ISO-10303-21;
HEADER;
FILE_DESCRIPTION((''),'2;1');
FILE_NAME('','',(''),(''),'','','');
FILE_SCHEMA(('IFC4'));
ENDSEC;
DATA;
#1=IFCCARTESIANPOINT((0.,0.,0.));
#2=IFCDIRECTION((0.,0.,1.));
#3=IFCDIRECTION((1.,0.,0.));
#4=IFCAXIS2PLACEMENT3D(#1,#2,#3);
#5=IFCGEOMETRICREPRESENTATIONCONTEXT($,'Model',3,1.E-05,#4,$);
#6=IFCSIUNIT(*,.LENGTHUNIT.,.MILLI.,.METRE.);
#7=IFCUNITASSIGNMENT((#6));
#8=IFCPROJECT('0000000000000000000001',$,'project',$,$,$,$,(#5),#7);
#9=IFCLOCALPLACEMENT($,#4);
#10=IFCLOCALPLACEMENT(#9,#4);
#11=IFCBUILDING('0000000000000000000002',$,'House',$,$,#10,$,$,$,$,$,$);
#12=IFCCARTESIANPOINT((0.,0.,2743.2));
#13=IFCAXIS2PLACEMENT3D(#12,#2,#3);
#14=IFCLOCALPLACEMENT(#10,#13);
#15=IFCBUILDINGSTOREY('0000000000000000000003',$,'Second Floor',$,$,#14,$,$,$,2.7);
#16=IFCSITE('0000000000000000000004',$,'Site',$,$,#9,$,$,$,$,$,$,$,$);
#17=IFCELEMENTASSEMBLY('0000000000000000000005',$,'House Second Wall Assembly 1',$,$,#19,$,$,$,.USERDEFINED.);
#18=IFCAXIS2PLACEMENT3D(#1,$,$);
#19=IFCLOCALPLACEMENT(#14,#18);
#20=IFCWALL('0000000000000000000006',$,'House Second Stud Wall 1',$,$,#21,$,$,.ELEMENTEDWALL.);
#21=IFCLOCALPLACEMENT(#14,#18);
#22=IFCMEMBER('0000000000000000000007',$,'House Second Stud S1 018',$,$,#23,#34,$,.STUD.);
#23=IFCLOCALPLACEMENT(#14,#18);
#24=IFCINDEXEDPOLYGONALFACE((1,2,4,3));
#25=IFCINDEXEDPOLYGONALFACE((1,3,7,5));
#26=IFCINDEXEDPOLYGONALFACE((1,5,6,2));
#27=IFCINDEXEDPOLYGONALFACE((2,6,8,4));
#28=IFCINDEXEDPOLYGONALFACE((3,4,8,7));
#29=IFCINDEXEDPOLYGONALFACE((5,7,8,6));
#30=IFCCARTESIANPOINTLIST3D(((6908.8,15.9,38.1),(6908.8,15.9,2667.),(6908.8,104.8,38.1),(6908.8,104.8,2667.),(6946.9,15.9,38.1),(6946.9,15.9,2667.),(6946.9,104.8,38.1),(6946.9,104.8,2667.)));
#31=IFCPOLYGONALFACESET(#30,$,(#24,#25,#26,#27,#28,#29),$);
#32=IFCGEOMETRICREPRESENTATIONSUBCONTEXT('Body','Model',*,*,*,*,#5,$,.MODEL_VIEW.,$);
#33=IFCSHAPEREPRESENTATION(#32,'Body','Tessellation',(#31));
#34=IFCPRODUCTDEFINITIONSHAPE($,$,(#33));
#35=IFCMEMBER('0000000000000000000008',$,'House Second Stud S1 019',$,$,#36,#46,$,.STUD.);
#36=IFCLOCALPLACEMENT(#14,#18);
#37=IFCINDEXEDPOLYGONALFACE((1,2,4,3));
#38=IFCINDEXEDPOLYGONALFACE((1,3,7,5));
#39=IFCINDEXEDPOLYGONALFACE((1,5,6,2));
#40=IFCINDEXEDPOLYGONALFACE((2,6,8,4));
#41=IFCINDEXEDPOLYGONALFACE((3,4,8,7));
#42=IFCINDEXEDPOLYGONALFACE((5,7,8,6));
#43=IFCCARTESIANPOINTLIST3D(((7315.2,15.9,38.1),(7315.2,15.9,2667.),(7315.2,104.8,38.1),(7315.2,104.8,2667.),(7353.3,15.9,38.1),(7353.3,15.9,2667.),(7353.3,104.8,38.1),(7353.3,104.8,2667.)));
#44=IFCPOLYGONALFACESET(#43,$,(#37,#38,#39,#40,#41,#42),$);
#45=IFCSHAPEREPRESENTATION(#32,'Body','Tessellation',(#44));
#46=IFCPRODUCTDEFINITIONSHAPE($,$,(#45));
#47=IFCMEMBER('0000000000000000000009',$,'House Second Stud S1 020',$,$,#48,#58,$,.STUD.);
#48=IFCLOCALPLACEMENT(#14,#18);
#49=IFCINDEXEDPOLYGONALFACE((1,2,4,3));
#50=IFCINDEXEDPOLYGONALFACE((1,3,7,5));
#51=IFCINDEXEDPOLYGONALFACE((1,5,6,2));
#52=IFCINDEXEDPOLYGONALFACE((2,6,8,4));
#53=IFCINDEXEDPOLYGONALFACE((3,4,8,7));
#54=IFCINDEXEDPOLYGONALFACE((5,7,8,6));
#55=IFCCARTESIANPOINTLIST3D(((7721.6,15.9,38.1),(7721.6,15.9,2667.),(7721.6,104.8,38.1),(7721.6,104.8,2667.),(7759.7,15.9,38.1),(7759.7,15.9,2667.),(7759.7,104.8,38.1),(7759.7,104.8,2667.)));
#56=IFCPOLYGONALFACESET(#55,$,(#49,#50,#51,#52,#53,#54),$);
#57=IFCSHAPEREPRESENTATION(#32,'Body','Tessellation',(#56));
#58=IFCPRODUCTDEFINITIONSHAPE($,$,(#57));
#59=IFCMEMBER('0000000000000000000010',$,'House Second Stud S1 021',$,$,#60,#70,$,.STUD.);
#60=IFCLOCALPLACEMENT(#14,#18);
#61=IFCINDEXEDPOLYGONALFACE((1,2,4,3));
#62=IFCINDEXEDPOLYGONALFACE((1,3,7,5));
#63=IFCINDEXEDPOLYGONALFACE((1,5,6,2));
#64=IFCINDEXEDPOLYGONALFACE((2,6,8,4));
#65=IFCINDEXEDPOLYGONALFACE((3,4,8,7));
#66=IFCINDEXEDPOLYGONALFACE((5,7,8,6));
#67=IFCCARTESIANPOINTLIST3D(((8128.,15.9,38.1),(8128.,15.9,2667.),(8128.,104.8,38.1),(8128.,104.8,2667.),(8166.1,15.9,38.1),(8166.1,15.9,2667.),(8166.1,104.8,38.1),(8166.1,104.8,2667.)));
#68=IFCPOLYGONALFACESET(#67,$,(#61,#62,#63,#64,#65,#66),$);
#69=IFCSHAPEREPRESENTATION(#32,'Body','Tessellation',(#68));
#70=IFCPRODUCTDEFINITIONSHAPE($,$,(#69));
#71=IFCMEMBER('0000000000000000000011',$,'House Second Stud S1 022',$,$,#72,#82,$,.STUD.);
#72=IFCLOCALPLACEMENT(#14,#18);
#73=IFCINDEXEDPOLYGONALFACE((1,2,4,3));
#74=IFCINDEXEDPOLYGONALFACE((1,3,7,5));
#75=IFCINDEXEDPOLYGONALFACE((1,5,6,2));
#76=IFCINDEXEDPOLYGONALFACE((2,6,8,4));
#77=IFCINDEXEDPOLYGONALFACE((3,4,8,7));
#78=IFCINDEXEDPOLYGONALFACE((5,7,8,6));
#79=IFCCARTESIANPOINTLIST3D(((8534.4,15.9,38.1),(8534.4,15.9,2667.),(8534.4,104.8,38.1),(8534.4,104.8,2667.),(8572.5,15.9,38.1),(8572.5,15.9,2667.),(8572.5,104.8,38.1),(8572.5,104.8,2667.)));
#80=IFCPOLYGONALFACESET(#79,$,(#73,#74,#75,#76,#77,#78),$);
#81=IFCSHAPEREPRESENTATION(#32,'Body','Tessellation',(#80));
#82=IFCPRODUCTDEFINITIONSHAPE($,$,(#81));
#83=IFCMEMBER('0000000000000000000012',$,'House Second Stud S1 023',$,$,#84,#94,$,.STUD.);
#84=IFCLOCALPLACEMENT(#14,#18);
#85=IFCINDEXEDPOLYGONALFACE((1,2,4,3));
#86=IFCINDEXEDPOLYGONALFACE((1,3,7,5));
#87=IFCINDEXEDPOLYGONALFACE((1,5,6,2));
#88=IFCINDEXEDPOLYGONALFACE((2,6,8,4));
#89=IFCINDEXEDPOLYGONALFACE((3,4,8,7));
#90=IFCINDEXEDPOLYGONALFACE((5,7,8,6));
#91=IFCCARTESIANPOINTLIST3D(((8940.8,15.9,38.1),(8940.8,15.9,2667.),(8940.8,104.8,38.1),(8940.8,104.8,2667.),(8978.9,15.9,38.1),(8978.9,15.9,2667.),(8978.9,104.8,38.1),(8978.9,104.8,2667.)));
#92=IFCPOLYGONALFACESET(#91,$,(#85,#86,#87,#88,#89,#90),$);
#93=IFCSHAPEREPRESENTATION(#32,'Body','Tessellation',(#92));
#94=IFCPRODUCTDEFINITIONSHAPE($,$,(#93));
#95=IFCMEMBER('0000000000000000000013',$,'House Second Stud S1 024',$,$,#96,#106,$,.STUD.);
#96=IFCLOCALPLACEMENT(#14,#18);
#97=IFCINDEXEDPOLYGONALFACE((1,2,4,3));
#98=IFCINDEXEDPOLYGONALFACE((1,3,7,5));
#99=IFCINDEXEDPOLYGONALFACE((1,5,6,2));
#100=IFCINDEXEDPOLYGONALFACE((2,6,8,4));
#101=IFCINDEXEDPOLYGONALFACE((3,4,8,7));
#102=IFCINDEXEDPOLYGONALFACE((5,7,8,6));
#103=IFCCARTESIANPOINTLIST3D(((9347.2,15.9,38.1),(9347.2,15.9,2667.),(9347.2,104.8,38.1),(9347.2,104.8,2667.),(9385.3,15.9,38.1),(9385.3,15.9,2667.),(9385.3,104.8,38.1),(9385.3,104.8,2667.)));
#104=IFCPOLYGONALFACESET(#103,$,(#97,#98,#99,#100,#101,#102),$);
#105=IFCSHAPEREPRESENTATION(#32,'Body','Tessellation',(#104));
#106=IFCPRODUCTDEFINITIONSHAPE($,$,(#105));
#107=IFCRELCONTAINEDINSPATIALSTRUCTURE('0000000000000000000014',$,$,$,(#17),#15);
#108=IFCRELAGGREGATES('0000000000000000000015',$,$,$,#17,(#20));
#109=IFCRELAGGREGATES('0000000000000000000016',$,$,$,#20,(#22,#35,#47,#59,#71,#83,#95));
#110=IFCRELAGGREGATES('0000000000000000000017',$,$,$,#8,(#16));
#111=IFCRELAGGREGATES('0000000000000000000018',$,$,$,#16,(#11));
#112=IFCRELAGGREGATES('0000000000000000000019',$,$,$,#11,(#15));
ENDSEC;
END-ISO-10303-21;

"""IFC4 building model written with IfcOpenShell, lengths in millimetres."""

from ifc_helpers import new_model, si_unit, frame, origin_with_axes, origin_2d, place, context, subcontext, project, spatial, rectangle, extrude, element, aggregate, save


model = new_model("IFC4")

# Units and contexts
model_context = context("Model", 3, precision=1e-05, world=origin_with_axes())
body_context = subcontext(model_context, "Body", "Model", "MODEL_VIEW")
ifc_project = project(units=[si_unit("LENGTHUNIT", "METRE", prefix="MILLI")], contexts=[model_context])

# Site, building, storey
site_placement = place(None, origin_with_axes())
site = spatial("IfcSite", under=ifc_project, at=site_placement, Name="Site")
building_placement = place(site_placement, origin_with_axes())
building = spatial("IfcBuilding", under=site, at=building_placement, Name="House")
storey_placement = place(building_placement, frame((0.0, 0.0, 2743.2), z_axis=(0.0, 0.0, 1.0), x_axis=(1.0, 0.0, 0.0)))
storey = spatial("IfcBuildingStorey", under=building, at=storey_placement, Name="Second Floor", Elevation=2.7)

# Element assembly, wall, members
assembly_placement = place(storey_placement, frame((0.0, 0.0, -2743.2), z_axis=(0.0, 0.0, 1.0), x_axis=(1.0, 0.0, 0.0)))
assembly = element("IfcElementAssembly", 1, at=assembly_placement, inside=storey, Name="House Second Wall Assembly 1", PredefinedType="USERDEFINED")
wall_placement = place(assembly_placement, frame((0.0, 0.0, 2743.2), z_axis=(0.0, 0.0, 1.0), x_axis=(1.0, 0.0, 0.0)))
wall = element("IfcWall", 2, at=wall_placement, Name="House Second Stud Wall 1", PredefinedType="ELEMENTEDWALL")
aggregate(assembly, [wall])
member_1_placement = place(wall_placement, frame((6927.9, 60.3, 38.1), z_axis=(0.0, 0.0, 1.0), x_axis=(1.0, 0.0, 0.0)))
member_1 = element("IfcMember", 3, at=member_1_placement, Name="House Second Stud S1 018", PredefinedType="STUD", context=body_context, shape_type="SweptSolid", body=[
    extrude(rectangle(XDim=38.1, YDim=88.9, at=origin_2d()), origin_with_axes(), (0.0, 0.0, 1.0), 2628.9),
])
member_2_placement = place(wall_placement, frame((7334.2, 60.3, 38.1), z_axis=(0.0, 0.0, 1.0), x_axis=(1.0, 0.0, 0.0)))
member_2 = element("IfcMember", 4, at=member_2_placement, Name="House Second Stud S1 019", PredefinedType="STUD", context=body_context, shape_type="SweptSolid", body=[
    extrude(rectangle(XDim=38.1, YDim=88.9, at=origin_2d()), origin_with_axes(), (0.0, 0.0, 1.0), 2628.9),
])
member_3_placement = place(wall_placement, frame((7740.6, 60.3, 38.1), z_axis=(0.0, 0.0, 1.0), x_axis=(1.0, 0.0, 0.0)))
member_3 = element("IfcMember", 5, at=member_3_placement, Name="House Second Stud S1 020", PredefinedType="STUD", context=body_context, shape_type="SweptSolid", body=[
    extrude(rectangle(XDim=38.1, YDim=88.9, at=origin_2d()), origin_with_axes(), (0.0, 0.0, 1.0), 2628.9),
])
member_4_placement = place(wall_placement, frame((8147.1, 60.3, 38.1), z_axis=(0.0, 0.0, 1.0), x_axis=(1.0, 0.0, 0.0)))
member_4 = element("IfcMember", 6, at=member_4_placement, Name="House Second Stud S1 021", PredefinedType="STUD", context=body_context, shape_type="SweptSolid", body=[
    extrude(rectangle(XDim=38.1, YDim=88.9, at=origin_2d()), origin_with_axes(), (0.0, 0.0, 1.0), 2628.9),
])
member_5_placement = place(wall_placement, frame((8553.5, 60.3, 38.1), z_axis=(0.0, 0.0, 1.0), x_axis=(1.0, 0.0, 0.0)))
member_5 = element("IfcMember", 7, at=member_5_placement, Name="House Second Stud S1 022", PredefinedType="STUD", context=body_context, shape_type="SweptSolid", body=[
    extrude(rectangle(XDim=38.1, YDim=88.9, at=origin_2d()), origin_with_axes(), (0.0, 0.0, 1.0), 2628.9),
])
member_6_placement = place(wall_placement, frame((8959.8, 60.3, 38.1), z_axis=(0.0, 0.0, 1.0), x_axis=(1.0, 0.0, 0.0)))
member_6 = element("IfcMember", 8, at=member_6_placement, Name="House Second Stud S1 023", PredefinedType="STUD", context=body_context, shape_type="SweptSolid", body=[
    extrude(rectangle(XDim=38.1, YDim=88.9, at=origin_2d()), origin_with_axes(), (0.0, 0.0, 1.0), 2628.9),
])
member_7_placement = place(wall_placement, frame((9366.2, 60.3, 38.1), z_axis=(0.0, 0.0, 1.0), x_axis=(1.0, 0.0, 0.0)))
member_7 = element("IfcMember", 9, at=member_7_placement, Name="House Second Stud S1 024", PredefinedType="STUD", context=body_context, shape_type="SweptSolid", body=[
    extrude(rectangle(XDim=38.1, YDim=88.9, at=origin_2d()), origin_with_axes(), (0.0, 0.0, 1.0), 2628.9),
])
aggregate(wall, [member_1, member_2, member_3, member_4, member_5, member_6, member_7])

save(model, "model.ifc")
